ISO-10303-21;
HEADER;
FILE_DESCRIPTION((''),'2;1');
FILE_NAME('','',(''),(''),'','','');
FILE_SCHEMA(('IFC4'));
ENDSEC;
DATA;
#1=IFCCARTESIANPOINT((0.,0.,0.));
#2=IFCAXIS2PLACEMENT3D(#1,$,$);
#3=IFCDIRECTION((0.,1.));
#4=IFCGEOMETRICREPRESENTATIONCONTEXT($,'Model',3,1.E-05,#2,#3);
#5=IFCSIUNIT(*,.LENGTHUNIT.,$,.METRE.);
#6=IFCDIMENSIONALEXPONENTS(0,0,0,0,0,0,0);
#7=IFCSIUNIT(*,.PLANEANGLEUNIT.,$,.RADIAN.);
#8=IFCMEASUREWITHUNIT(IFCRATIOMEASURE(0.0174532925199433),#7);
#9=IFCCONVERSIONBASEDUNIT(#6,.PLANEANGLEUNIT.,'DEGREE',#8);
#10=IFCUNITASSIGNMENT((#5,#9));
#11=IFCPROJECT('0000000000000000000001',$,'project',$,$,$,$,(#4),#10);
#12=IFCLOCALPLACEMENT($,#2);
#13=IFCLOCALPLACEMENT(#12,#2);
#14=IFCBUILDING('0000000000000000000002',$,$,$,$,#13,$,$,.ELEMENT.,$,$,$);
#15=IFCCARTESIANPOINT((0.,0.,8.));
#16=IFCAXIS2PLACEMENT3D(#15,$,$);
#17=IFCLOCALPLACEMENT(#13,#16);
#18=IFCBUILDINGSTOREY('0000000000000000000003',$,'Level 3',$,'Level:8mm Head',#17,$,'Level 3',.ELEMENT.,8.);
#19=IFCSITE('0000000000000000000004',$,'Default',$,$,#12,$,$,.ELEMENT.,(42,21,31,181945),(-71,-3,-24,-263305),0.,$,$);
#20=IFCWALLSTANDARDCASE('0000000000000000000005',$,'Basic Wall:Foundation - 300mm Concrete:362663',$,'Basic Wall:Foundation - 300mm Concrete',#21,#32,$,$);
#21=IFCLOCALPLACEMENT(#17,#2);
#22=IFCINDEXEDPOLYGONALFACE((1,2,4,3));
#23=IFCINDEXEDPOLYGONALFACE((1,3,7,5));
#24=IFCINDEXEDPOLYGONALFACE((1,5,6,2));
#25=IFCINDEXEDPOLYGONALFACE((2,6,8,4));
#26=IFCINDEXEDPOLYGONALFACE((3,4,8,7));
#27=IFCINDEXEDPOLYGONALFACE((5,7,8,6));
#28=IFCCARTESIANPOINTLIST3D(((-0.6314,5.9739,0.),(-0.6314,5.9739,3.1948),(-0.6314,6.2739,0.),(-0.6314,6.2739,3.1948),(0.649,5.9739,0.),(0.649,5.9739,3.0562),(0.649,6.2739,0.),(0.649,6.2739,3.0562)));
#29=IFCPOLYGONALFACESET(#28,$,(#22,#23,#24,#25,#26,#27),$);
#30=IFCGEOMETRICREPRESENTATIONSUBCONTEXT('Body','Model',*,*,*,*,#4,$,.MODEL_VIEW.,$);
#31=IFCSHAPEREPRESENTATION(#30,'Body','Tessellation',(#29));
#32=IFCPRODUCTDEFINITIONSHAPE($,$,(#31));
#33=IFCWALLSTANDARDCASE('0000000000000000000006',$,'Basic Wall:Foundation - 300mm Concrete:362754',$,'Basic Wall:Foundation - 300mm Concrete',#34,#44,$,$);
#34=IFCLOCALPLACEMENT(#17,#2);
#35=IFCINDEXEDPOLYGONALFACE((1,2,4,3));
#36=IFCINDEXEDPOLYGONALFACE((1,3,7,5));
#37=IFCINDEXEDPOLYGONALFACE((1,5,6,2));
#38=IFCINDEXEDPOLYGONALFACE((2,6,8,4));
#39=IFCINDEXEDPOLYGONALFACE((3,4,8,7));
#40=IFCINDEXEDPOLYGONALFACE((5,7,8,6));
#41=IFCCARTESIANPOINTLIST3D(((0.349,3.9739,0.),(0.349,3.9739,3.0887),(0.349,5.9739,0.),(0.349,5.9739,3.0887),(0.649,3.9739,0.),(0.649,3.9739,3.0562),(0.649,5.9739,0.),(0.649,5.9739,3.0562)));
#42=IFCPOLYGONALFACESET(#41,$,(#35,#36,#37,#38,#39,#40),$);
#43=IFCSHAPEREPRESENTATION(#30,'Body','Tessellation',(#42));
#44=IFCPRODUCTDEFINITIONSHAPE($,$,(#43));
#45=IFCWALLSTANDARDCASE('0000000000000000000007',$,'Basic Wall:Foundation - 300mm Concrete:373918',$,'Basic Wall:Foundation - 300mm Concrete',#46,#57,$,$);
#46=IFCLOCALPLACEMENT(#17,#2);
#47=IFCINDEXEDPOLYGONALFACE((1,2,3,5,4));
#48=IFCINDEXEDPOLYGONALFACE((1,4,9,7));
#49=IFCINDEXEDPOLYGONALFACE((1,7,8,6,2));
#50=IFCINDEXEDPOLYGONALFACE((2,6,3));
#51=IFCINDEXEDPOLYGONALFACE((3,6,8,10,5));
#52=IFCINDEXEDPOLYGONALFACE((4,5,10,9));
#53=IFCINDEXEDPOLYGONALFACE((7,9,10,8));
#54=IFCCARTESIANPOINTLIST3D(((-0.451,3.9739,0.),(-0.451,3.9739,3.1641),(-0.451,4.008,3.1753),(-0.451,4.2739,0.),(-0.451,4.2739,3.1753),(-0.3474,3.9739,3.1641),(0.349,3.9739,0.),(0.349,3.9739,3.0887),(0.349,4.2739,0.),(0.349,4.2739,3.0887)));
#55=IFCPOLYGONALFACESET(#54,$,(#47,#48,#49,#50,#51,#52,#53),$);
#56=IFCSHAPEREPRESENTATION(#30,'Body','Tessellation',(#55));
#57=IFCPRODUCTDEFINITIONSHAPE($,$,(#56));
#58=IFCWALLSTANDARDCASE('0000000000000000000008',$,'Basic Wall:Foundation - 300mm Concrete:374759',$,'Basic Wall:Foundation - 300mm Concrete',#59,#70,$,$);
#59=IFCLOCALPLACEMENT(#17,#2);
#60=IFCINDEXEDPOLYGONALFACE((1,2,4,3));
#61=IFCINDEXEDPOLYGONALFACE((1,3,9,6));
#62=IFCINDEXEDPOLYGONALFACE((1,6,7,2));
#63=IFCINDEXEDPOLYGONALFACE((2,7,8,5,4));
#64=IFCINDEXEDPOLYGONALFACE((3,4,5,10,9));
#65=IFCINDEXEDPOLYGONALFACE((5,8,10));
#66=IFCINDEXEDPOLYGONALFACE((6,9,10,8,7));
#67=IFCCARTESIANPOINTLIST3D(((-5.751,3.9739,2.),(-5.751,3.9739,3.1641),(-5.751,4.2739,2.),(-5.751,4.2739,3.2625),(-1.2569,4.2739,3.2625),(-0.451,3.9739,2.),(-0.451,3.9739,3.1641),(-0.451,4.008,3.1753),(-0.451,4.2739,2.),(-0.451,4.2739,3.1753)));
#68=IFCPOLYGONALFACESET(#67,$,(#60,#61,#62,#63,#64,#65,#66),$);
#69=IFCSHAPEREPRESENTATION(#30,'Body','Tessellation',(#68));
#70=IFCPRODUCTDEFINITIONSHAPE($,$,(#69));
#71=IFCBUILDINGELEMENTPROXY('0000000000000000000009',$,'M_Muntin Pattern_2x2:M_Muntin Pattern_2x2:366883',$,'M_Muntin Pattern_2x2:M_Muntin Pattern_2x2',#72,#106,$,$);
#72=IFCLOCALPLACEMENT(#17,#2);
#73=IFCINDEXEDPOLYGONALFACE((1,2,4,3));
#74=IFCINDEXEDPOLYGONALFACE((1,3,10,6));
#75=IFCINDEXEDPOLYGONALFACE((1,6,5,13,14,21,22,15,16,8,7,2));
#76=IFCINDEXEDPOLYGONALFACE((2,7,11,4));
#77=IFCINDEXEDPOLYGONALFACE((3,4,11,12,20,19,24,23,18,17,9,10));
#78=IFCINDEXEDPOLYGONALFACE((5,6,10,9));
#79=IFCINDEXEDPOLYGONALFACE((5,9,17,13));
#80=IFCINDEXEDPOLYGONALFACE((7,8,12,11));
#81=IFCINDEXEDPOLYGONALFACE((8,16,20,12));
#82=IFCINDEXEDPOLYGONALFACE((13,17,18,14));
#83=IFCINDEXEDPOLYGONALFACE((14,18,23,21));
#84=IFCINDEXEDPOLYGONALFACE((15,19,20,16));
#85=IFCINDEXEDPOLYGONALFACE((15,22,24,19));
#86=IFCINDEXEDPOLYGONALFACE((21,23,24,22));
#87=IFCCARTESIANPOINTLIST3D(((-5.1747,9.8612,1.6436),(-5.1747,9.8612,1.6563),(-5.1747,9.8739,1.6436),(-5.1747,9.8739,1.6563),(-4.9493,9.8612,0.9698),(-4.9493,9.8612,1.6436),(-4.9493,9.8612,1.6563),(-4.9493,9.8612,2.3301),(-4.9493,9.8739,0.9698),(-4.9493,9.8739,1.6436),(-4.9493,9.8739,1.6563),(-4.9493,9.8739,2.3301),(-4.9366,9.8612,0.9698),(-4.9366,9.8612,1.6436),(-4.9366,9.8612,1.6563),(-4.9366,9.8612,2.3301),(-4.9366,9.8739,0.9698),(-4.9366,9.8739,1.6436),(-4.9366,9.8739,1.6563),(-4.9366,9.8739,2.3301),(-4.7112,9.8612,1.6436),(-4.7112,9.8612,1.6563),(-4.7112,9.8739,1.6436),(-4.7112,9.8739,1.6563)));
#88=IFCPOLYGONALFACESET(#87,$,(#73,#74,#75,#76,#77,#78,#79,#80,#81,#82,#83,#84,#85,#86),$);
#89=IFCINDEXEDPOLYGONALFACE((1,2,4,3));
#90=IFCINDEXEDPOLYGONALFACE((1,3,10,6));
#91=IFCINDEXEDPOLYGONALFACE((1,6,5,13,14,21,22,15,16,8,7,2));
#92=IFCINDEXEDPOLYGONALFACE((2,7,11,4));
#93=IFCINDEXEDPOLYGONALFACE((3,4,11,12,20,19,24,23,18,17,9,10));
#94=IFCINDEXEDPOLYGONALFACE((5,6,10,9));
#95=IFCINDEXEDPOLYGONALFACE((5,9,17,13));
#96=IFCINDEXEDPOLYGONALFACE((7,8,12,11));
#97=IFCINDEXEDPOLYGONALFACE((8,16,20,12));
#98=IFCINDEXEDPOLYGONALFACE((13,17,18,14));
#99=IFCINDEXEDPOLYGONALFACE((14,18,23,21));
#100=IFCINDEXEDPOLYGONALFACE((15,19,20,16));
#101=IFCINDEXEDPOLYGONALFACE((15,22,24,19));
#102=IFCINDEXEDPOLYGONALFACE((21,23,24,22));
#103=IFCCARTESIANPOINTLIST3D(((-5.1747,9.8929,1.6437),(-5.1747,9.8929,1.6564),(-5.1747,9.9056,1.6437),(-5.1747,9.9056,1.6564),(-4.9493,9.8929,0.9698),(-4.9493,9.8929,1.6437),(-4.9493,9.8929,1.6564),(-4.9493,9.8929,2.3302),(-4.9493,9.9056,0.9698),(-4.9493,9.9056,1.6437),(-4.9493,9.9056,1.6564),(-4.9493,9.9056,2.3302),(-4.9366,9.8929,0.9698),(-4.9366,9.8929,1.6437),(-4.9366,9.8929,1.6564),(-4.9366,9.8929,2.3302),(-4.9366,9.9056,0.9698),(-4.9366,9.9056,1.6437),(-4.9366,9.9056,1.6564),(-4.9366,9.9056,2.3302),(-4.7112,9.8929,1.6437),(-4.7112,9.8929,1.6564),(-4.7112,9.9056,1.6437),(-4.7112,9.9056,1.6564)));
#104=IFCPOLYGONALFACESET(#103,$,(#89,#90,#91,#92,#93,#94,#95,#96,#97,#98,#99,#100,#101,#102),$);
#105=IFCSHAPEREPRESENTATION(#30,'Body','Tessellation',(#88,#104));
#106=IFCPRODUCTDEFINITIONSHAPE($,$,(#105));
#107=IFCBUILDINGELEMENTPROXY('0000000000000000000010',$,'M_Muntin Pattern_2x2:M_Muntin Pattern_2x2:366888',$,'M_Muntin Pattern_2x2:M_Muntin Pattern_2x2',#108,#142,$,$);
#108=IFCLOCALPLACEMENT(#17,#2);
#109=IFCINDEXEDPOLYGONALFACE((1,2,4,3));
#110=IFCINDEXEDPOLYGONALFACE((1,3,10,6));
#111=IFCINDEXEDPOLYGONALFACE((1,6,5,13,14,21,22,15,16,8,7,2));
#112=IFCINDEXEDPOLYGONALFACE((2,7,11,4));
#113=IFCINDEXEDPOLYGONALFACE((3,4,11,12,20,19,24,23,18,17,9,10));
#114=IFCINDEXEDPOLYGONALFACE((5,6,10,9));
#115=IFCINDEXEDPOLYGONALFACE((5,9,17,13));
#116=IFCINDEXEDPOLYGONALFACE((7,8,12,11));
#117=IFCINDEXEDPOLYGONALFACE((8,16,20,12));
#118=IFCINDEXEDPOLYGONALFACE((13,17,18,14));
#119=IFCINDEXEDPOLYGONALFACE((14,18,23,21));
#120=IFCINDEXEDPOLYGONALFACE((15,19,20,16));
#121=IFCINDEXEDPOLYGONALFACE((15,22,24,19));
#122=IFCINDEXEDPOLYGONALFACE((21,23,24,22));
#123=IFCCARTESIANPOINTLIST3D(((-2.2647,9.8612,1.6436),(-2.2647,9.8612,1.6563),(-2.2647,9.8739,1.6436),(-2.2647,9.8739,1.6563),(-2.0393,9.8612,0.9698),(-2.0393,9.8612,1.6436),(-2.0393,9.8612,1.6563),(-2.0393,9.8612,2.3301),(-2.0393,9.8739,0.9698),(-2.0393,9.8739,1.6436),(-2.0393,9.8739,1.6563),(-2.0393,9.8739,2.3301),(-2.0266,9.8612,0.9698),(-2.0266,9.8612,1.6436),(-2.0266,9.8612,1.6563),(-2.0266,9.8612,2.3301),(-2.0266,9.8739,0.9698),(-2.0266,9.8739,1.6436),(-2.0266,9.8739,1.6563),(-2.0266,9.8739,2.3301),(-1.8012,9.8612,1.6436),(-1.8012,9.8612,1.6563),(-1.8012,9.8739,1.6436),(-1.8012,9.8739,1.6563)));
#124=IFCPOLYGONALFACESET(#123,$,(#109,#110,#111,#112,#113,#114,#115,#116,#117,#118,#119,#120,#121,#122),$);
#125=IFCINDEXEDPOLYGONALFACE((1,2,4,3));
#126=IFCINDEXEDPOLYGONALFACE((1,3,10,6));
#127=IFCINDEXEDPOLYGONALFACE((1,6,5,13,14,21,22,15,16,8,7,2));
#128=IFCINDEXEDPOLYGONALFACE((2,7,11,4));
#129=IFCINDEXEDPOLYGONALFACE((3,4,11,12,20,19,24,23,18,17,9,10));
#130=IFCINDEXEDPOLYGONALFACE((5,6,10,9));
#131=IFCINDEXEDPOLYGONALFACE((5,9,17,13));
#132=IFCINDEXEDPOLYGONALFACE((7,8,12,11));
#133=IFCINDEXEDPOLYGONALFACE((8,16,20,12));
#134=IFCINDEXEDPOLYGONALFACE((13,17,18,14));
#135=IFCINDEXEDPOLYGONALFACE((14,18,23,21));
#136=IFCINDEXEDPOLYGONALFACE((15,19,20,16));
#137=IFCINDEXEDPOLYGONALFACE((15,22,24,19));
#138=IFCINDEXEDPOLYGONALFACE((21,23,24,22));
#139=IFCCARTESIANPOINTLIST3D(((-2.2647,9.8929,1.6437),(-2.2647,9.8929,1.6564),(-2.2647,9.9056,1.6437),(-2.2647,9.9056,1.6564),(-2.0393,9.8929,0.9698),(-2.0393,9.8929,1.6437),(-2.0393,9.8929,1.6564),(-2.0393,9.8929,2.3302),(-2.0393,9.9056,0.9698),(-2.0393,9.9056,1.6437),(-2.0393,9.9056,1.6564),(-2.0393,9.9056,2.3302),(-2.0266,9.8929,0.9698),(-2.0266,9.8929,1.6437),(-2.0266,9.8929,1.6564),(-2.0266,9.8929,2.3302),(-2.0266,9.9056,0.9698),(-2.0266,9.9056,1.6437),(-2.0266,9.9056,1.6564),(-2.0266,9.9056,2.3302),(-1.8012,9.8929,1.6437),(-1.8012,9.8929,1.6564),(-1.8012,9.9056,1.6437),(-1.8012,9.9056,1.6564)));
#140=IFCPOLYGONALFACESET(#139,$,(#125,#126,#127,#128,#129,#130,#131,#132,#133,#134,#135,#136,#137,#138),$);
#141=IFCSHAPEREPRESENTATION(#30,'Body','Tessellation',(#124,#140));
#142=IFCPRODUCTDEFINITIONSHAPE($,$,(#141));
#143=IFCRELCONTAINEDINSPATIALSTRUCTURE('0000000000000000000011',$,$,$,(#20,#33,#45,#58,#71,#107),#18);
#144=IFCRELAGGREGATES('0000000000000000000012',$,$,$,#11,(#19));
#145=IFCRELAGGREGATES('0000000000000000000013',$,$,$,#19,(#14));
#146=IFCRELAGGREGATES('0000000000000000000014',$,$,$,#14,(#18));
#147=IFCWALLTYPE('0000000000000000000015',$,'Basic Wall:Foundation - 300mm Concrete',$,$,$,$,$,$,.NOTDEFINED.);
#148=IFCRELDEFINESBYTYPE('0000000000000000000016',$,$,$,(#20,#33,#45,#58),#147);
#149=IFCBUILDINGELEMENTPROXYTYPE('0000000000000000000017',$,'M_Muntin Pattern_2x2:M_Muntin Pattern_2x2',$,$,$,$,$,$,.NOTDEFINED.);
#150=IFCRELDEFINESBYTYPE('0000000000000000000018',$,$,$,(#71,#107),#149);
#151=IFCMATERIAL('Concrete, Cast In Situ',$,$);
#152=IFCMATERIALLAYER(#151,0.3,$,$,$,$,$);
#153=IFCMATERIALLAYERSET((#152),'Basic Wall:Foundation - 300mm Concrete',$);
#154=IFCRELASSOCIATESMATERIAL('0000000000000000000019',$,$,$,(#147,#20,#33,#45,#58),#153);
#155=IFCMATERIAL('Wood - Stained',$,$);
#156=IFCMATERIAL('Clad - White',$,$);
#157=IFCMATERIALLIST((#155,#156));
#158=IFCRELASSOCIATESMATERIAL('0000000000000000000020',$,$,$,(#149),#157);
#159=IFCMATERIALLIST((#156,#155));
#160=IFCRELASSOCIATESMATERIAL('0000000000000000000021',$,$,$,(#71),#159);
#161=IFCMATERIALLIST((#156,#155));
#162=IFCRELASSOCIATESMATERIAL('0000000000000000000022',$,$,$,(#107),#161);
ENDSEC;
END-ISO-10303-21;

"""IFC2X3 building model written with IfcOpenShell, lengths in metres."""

from ifc_helpers import new_model, entity, si_unit, converted_unit, direction, frame, frame_2d, origin, place, context, subcontext, project, spatial, polyline, rectangle, outline, extrude, clip, bounded_halfspace, source, transform, mapped, material, material_list, layer, layer_set, layer_usage, type_object, type_shapes, element, save


model = new_model("IFC2X3")

# Units and contexts
model_context = context("Model", 3, precision=1e-05, world=origin(), true_north=direction((0.0, 1.0)))
body_context = subcontext(model_context, "Body", "Model", "MODEL_VIEW")
ifc_project = project(units=[si_unit("LENGTHUNIT", "METRE"), converted_unit("PLANEANGLEUNIT", "DEGREE", entity("IfcRatioMeasure", 0.0174532925199433), si_unit("PLANEANGLEUNIT", "RADIAN"), dimensions=[0, 0, 0, 0, 0, 0, 0])], contexts=[model_context])

# Site, building, storey
site_placement = place(None, origin())
site = spatial("IfcSite", under=ifc_project, at=site_placement, Name="Default", CompositionType="ELEMENT", RefLatitude=(42, 21, 31, 181945), RefLongitude=(-71, -3, -24, -263305), RefElevation=0.0)
building_placement = place(site_placement, origin())
building = spatial("IfcBuilding", under=site, at=building_placement, CompositionType="ELEMENT")
storey_placement = place(building_placement, frame((0.0, 0.0, 8.0)))
storey = spatial("IfcBuildingStorey", under=building, at=storey_placement, Name="Level 3", ObjectType="Level:8mm Head", LongName="Level 3", CompositionType="ELEMENT", Elevation=8.0)

# Wall
ifc_material_1 = material(Name="Concrete, Cast In Situ")
ifc_layer_1 = layer(ifc_material_1, 0.3)
ifc_layer_set_1 = layer_set([ifc_layer_1], Name="Basic Wall:Foundation - 300mm Concrete")
ifc_layer_usage_1 = layer_usage(ifc_layer_set_1, "AXIS2", "NEGATIVE", 0.15)
wall_type = type_object("IfcWallType", Name="Basic Wall:Foundation - 300mm Concrete", PredefinedType="NOTDEFINED", material=ifc_layer_set_1)
wall_1_placement = place(storey_placement, frame((-0.6314, 6.1239, 0.0)))
element("IfcWallStandardCase", 1, at=wall_1_placement, inside=storey, type_object=wall_type, material=ifc_layer_usage_1, Name="Basic Wall:Foundation - 300mm Concrete:362663", ObjectType="Basic Wall:Foundation - 300mm Concrete", context=body_context, shape_type="Clipping", body=[
    clip(extrude(rectangle(XDim=1.2804, YDim=0.3, at=frame_2d((0.6402, 0.0), x_axis=(-1.0, 0.0))), origin(), (0.0, 0.0, 1.0), 3.1948), bounded_halfspace(frame((0.0, -0.15, 3.1948), z_axis=(0.10761, 0.0, 0.994193), x_axis=(0.0, 1.0, 0.0)), False, frame((0.0, -0.15, 3.1948)), polyline([(0.0, 0.0), (0.9804, 0.0), (1.2804, 0.0), (1.2804, 0.3), (0.0, 0.3), (0.0, 0.0)]))),
])

# Walls
ifc_layer_usage_2 = layer_usage(ifc_layer_set_1, "AXIS2", "NEGATIVE", 0.15)
wall_2_placement = place(storey_placement, frame((0.499, 5.9739, 0.0), z_axis=(0.0, 0.0, 1.0), x_axis=(0.0, -1.0, 0.0)))
element("IfcWallStandardCase", 2, at=wall_2_placement, inside=storey, type_object=wall_type, material=ifc_layer_usage_2, Name="Basic Wall:Foundation - 300mm Concrete:362754", ObjectType="Basic Wall:Foundation - 300mm Concrete", context=body_context, shape_type="Clipping", body=[
    clip(extrude(rectangle(XDim=2.0, YDim=0.3, at=frame_2d((1.0, 0.0), x_axis=(-1.0, 0.0))), origin(), (0.0, 0.0, 1.0), 3.0887), bounded_halfspace(frame((0.0, -0.15, 3.0887), z_axis=(0.0, 0.10761, 0.994193), x_axis=(-1.0, 0.0, 0.0)), False, frame((0.0, -0.15, 3.0887)), polyline([(0.0, 0.0), (1.7, 0.0), (2.0, 0.0), (2.0, 0.3), (0.0, 0.3), (0.0, 0.0)]))),
])
ifc_layer_usage_3 = layer_usage(ifc_layer_set_1, "AXIS2", "NEGATIVE", 0.15)
wall_3_placement = place(storey_placement, frame((0.349, 4.1239, 0.0), z_axis=(0.0, 0.0, 1.0), x_axis=(-1.0, 0.0, 0.0)))
element("IfcWallStandardCase", 3, at=wall_3_placement, inside=storey, type_object=wall_type, material=ifc_layer_usage_3, Name="Basic Wall:Foundation - 300mm Concrete:373918", ObjectType="Basic Wall:Foundation - 300mm Concrete", context=body_context, shape_type="Clipping", body=[
    clip(clip(extrude(rectangle(XDim=0.8, YDim=0.3, at=frame_2d((0.4, 0.0), x_axis=(-1.0, 0.0))), origin(), (0.0, 0.0, 1.0), 3.1753), bounded_halfspace(frame((0.8, 0.1158, 3.1753), z_axis=(0.0, 0.311814, 0.950143), x_axis=(-1.0, 0.0, 0.0)), False, frame((0.8, 0.1158, 3.1753)), polyline([(0.0, 0.0), (0.0, 0.0342), (-0.1036, 0.0342), (0.0, 0.0)]))), bounded_halfspace(frame((0.0, -0.15, 3.0887), z_axis=(-0.10761, 0.0, 0.994193), x_axis=(0.0, -1.0, 0.0)), False, frame((0.0, -0.15, 3.0887)), polyline([(0.0, 0.0), (0.8, 0.0), (0.8, 0.2658), (0.6964, 0.3), (0.0, 0.3), (0.0, 0.0)]))),
])
ifc_layer_usage_4 = layer_usage(ifc_layer_set_1, "AXIS2", "NEGATIVE", 0.15)
wall_4_placement = place(storey_placement, frame((-5.751, 4.1239, 2.0)))
element("IfcWallStandardCase", 4, at=wall_4_placement, inside=storey, type_object=wall_type, material=ifc_layer_usage_4, Name="Basic Wall:Foundation - 300mm Concrete:374759", ObjectType="Basic Wall:Foundation - 300mm Concrete", context=body_context, shape_type="Clipping", body=[
    clip(clip(extrude(rectangle(XDim=5.3, YDim=0.3, at=frame_2d((2.65, 0.0), x_axis=(-1.0, 0.0))), origin(), (0.0, 0.0, 1.0), 1.2625), bounded_halfspace(frame((0.0, -0.15, 1.1641), z_axis=(0.0, -0.311814, 0.950143), x_axis=(1.0, 0.0, 0.0)), False, frame((0.0, -0.15, 1.1641)), polyline([(0.0, 0.0), (5.3, 0.0), (5.3, 0.0342), (4.494, 0.3), (0.0, 0.3), (0.0, 0.0)]))), bounded_halfspace(frame((5.3, -0.1158, 1.1753), z_axis=(0.10761, 0.0, 0.994193), x_axis=(0.0, 1.0, 0.0)), False, frame((5.3, -0.1158, 1.1753)), polyline([(0.0, 0.0), (0.0, 0.2658), (-0.806, 0.2658), (0.0, 0.0)]))),
])

# Building element proxies
ifc_material_2 = material(Name="Clad - White")
ifc_material_3 = material(Name="Wood - Stained")
ifc_material_list_1 = material_list([ifc_material_2, ifc_material_3])
ifc_material_list_2 = material_list([ifc_material_3, ifc_material_2])
building_element_proxy_type_1 = type_object("IfcBuildingElementProxyType", Name="M_Muntin Pattern_2x2:M_Muntin Pattern_2x2", PredefinedType="NOTDEFINED", material=ifc_material_list_2)
shared_shape_1 = source(origin(), body_context, "Body", "SweptSolid", [
    extrude(outline(polyline([(0.0064, -0.0064), (0.6801, -0.0064), (0.6801, 0.0063), (0.0064, 0.0063), (0.0064, 0.2317), (-0.0063, 0.2317), (-0.0063, 0.0063), (-0.6802, 0.0063), (-0.6802, -0.0064), (-0.0063, -0.0064), (-0.0063, -0.2317), (0.0064, -0.2317), (0.0064, -0.0064)])), frame((0.0, 0.0095, 0.6801), z_axis=(0.0, 1.0, 0.0), x_axis=(0.0, 0.0, 1.0)), (0.0, 0.0, 1.0), 0.0127),
    extrude(outline(polyline([(0.0064, -0.0064), (0.6802, -0.0064), (0.6802, 0.0063), (0.0064, 0.0063), (0.0064, 0.2317), (-0.0063, 0.2317), (-0.0063, 0.0063), (-0.6802, 0.0063), (-0.6802, -0.0064), (-0.0063, -0.0064), (-0.0063, -0.2317), (0.0064, -0.2317), (0.0064, -0.0064)])), frame((0.0, -0.0222, 0.6802), z_axis=(0.0, 1.0, 0.0), x_axis=(0.0, 0.0, 1.0)), (0.0, 0.0, 1.0), 0.0127),
])
type_shapes(building_element_proxy_type_1, [shared_shape_1])
proxy_1_placement = place(storey_placement, frame((-4.943, 9.8834, 0.9698), z_axis=(0.0, 0.0, 1.0), x_axis=(-1.0, 0.0, 0.0)))
element("IfcBuildingElementProxy", 5, at=proxy_1_placement, inside=storey, type_object=building_element_proxy_type_1, material=ifc_material_list_1, Name="M_Muntin Pattern_2x2:M_Muntin Pattern_2x2:366883", ObjectType="M_Muntin Pattern_2x2:M_Muntin Pattern_2x2", context=body_context, shape_type="MappedRepresentation", body=[
    mapped(shared_shape_1, transform((0.0, 0.0, 0.0), scale=1.0)),
])
ifc_material_list_3 = material_list([ifc_material_2, ifc_material_3])
proxy_2_placement = place(storey_placement, frame((-2.033, 9.8834, 0.9698), z_axis=(0.0, 0.0, 1.0), x_axis=(-1.0, 0.0, 0.0)))
element("IfcBuildingElementProxy", 6, at=proxy_2_placement, inside=storey, type_object=building_element_proxy_type_1, material=ifc_material_list_3, Name="M_Muntin Pattern_2x2:M_Muntin Pattern_2x2:366888", ObjectType="M_Muntin Pattern_2x2:M_Muntin Pattern_2x2", context=body_context, shape_type="MappedRepresentation", body=[
    mapped(shared_shape_1, transform((0.0, 0.0, 0.0), scale=1.0)),
])

save(model, "model.ifc")
